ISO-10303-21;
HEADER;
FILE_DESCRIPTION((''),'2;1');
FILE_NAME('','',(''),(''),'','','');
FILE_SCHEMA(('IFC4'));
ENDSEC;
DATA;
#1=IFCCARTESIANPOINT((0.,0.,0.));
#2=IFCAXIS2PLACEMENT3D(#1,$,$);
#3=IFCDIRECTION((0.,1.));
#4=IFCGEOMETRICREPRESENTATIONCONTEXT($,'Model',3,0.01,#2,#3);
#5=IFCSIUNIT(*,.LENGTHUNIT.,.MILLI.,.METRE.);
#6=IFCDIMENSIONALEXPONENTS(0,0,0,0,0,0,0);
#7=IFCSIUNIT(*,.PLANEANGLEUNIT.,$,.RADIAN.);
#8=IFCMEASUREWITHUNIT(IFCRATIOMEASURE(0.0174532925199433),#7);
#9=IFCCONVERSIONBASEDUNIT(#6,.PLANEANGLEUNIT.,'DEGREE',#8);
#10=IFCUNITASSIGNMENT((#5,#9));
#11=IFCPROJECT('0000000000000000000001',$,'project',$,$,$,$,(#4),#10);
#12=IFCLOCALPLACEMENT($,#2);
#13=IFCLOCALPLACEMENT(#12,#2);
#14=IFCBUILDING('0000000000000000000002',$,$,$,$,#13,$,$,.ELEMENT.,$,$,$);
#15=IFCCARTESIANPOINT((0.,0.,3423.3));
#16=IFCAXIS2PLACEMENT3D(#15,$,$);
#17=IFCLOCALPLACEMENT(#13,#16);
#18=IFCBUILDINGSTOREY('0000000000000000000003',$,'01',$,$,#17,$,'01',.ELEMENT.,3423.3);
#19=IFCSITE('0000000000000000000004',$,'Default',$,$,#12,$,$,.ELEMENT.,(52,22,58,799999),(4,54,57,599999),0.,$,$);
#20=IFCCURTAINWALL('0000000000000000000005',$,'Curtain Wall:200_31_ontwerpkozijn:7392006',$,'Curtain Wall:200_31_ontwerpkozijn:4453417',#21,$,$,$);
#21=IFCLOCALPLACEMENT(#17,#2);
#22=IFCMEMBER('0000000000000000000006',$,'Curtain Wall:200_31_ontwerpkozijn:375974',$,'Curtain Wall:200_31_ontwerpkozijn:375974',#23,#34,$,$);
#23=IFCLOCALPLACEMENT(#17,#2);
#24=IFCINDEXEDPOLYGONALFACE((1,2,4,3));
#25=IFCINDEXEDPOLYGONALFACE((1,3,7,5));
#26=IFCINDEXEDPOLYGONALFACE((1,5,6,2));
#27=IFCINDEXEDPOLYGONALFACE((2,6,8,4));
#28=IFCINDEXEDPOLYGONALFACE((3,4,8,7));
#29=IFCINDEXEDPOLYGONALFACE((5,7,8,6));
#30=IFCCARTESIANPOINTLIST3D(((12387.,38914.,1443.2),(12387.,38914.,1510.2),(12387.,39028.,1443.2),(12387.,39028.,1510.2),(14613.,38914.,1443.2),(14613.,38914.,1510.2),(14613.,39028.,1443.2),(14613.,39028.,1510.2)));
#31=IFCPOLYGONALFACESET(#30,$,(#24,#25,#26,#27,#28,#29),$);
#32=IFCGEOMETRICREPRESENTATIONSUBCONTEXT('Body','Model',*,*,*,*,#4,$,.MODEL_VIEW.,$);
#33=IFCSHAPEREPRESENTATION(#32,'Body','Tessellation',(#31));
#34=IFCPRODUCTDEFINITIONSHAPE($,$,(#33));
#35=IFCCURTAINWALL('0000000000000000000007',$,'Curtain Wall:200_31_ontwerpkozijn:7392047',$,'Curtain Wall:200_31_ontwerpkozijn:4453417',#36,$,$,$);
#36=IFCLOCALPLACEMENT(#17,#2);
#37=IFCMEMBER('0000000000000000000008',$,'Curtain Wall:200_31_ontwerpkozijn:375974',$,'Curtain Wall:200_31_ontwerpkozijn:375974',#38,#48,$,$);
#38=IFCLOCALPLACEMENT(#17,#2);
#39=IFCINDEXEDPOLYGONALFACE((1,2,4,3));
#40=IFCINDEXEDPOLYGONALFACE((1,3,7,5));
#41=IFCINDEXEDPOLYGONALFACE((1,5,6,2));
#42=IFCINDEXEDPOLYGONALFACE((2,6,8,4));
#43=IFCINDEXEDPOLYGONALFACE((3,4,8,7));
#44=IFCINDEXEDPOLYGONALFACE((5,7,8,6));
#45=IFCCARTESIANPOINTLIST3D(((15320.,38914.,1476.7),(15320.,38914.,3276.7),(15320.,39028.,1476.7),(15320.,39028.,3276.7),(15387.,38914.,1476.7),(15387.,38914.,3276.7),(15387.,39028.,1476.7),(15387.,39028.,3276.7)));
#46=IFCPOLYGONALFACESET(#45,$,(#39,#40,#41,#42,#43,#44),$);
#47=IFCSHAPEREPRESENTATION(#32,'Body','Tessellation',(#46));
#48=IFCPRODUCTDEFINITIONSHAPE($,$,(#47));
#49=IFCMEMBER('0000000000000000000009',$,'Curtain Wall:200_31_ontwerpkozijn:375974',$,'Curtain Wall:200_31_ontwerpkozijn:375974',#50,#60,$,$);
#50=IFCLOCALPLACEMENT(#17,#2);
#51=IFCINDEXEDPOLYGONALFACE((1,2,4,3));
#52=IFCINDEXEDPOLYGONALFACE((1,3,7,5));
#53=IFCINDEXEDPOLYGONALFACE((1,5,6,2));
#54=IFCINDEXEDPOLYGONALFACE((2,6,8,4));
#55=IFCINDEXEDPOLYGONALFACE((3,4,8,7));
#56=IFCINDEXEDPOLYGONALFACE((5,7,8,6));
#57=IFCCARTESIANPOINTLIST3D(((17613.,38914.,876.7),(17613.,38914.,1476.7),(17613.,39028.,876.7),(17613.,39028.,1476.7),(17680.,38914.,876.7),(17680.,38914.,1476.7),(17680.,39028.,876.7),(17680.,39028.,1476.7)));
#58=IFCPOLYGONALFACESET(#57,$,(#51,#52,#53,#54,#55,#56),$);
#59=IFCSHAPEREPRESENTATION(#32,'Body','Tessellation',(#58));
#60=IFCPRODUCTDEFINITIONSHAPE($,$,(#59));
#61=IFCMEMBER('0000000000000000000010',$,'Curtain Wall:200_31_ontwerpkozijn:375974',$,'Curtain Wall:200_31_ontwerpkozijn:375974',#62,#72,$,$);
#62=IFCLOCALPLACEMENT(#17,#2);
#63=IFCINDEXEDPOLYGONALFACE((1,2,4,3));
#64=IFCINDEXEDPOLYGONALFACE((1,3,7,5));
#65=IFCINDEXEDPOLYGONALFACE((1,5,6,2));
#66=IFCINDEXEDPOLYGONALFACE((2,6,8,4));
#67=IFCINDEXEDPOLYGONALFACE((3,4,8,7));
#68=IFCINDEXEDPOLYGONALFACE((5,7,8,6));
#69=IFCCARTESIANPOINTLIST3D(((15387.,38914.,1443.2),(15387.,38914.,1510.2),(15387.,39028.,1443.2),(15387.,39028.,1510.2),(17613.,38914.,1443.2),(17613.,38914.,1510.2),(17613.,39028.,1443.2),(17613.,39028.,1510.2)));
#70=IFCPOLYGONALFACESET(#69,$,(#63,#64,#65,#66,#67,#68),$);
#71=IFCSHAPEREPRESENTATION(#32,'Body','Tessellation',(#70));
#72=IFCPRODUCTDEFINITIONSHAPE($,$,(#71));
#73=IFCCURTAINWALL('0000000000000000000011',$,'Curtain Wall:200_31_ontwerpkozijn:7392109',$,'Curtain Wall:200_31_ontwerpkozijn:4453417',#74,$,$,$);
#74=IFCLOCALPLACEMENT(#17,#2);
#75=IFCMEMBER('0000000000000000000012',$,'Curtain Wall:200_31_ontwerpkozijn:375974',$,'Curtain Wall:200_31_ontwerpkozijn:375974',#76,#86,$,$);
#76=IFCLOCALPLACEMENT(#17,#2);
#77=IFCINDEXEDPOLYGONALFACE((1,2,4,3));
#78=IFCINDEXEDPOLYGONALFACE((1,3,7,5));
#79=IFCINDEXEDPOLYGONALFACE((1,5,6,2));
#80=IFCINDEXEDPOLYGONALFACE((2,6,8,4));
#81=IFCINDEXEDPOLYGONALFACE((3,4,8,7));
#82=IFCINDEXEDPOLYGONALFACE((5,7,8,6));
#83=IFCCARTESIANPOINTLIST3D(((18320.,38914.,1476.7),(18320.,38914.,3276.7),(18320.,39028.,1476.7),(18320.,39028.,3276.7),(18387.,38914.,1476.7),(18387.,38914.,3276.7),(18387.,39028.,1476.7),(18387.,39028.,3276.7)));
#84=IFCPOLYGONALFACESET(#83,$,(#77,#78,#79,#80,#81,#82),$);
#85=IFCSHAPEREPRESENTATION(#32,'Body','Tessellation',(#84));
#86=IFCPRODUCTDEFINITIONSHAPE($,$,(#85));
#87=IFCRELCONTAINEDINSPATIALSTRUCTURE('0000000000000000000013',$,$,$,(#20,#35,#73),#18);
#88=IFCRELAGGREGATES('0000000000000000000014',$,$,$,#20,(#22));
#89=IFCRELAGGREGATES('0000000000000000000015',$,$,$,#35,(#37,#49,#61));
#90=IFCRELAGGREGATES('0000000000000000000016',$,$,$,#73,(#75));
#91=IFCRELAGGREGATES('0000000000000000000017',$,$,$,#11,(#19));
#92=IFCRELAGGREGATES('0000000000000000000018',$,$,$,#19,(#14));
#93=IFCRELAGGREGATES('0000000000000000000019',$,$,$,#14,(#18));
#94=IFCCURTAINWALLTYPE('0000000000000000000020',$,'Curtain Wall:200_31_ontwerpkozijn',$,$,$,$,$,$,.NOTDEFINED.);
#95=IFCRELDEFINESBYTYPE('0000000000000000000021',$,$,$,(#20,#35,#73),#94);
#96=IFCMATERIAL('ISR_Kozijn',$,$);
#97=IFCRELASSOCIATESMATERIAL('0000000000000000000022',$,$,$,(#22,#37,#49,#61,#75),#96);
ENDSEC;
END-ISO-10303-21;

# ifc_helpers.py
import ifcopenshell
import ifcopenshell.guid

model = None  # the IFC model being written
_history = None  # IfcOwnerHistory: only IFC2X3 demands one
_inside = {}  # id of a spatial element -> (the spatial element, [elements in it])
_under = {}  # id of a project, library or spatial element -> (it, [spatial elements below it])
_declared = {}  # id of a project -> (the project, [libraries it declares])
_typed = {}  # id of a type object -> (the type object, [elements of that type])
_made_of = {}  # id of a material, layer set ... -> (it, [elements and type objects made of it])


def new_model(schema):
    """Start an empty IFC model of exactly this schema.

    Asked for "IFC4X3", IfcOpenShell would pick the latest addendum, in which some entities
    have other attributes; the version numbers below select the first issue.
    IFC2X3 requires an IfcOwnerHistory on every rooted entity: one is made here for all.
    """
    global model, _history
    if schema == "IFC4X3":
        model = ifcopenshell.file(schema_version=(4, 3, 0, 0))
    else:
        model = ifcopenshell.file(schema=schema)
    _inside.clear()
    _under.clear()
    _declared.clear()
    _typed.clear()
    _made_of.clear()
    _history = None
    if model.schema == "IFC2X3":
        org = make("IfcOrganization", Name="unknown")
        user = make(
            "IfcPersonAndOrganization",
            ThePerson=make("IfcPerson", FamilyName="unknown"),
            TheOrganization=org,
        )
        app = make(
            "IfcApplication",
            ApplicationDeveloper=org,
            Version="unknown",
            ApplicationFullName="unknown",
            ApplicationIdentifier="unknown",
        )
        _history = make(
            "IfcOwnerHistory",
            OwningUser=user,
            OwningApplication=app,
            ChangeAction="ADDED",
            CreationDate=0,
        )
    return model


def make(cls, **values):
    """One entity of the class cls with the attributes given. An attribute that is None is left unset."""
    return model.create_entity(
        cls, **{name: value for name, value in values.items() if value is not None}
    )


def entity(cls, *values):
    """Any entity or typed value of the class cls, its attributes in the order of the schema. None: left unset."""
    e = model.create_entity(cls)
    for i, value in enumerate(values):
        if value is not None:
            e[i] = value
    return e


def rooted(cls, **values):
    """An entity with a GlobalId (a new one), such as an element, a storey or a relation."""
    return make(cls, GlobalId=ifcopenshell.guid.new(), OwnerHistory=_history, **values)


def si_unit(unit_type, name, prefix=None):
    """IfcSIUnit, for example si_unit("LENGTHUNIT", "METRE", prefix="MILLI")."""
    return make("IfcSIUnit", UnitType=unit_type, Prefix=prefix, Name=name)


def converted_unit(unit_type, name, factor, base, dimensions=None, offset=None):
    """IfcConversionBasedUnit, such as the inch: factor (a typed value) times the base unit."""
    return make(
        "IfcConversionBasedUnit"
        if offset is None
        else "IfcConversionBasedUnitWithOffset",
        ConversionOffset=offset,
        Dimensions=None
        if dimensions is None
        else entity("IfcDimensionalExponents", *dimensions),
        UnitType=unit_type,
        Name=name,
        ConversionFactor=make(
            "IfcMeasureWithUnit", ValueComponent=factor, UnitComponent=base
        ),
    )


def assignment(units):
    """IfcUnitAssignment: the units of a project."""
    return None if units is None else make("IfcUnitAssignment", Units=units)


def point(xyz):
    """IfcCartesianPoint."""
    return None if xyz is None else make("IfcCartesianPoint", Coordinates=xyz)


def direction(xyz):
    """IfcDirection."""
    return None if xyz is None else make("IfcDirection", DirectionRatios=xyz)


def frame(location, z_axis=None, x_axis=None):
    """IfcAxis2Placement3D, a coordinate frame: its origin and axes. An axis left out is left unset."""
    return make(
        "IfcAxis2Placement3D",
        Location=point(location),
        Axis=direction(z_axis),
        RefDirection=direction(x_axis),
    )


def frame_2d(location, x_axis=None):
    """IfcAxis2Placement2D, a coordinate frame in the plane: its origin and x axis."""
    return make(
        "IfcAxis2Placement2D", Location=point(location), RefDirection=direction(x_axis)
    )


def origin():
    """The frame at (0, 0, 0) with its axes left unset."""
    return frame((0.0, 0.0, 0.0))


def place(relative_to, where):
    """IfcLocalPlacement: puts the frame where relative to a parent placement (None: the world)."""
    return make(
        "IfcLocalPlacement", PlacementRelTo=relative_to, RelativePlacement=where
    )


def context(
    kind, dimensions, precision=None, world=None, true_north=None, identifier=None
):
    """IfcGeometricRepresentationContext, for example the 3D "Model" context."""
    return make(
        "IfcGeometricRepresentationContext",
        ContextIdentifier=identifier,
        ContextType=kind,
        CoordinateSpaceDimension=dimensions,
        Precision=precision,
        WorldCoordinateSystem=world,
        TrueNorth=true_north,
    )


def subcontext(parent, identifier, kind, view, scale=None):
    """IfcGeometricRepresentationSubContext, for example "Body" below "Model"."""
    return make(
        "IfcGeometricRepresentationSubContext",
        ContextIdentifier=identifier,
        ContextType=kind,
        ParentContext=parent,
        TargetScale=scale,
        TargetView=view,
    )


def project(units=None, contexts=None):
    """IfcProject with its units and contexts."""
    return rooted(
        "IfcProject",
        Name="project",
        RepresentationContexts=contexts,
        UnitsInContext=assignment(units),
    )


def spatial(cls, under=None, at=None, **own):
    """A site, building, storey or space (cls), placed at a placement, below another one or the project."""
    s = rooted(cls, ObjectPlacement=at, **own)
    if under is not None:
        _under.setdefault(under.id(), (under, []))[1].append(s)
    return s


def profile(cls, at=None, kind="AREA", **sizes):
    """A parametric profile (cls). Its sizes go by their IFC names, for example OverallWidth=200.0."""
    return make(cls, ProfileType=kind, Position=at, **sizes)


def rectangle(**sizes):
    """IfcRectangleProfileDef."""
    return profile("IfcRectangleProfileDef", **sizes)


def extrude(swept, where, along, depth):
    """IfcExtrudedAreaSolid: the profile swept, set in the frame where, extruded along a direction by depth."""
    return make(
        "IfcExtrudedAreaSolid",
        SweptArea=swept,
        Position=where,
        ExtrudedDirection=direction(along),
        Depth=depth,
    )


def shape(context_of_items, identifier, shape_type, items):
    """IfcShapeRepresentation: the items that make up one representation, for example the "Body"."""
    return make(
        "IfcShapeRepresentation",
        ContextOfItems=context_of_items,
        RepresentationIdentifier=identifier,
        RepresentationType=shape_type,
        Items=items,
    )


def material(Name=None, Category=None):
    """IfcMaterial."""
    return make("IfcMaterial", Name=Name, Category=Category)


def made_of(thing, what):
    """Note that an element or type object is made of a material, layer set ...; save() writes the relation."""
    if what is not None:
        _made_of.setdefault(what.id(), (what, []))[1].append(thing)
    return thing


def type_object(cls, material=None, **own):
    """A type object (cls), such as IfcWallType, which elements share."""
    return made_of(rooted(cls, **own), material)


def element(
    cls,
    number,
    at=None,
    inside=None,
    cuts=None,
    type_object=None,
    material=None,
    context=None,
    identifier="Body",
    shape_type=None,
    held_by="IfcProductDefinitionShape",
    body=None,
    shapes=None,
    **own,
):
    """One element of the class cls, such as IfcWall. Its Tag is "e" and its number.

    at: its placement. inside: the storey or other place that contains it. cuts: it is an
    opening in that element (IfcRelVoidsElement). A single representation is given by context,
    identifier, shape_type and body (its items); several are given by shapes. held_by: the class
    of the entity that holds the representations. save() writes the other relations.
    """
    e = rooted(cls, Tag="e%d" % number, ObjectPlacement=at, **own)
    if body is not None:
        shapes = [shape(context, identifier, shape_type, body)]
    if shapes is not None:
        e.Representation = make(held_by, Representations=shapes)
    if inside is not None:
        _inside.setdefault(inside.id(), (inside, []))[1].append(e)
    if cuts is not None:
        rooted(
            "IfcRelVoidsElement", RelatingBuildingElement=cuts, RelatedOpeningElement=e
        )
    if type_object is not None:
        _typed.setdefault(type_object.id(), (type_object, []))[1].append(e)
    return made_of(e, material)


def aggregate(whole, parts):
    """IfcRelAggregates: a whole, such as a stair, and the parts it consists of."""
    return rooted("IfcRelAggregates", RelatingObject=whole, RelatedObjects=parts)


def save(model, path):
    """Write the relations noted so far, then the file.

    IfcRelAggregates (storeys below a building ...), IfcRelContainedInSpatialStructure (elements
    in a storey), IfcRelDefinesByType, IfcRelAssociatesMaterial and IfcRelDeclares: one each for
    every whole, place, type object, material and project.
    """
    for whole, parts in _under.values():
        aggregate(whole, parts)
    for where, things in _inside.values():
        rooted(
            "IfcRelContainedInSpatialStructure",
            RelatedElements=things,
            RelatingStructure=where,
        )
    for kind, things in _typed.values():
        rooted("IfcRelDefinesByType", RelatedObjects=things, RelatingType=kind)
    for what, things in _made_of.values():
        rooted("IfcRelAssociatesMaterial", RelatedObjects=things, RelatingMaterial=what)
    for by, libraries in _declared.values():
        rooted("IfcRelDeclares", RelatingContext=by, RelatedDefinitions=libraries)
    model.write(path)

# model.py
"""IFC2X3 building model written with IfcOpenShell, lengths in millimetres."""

from ifc_helpers import new_model, entity, si_unit, converted_unit, direction, frame, frame_2d, origin, place, context, subcontext, project, spatial, rectangle, extrude, material, type_object, element, aggregate, save


model = new_model("IFC2X3")

# Units and contexts
model_context = context("Model", 3, precision=0.01, world=origin(), true_north=direction((0.0, 1.0)))
body_context = subcontext(model_context, "Body", "Model", "MODEL_VIEW")
ifc_project = project(units=[si_unit("LENGTHUNIT", "METRE", prefix="MILLI"), converted_unit("PLANEANGLEUNIT", "DEGREE", entity("IfcRatioMeasure", 0.0174532925199433), si_unit("PLANEANGLEUNIT", "RADIAN"), dimensions=[0, 0, 0, 0, 0, 0, 0])], contexts=[model_context])

# Site, building, storey
site_placement = place(None, origin())
site = spatial("IfcSite", under=ifc_project, at=site_placement, Name="Default", CompositionType="ELEMENT", RefLatitude=(52, 22, 58, 799999), RefLongitude=(4, 54, 57, 599999), RefElevation=0.0)
building_placement = place(site_placement, origin())
building = spatial("IfcBuilding", under=site, at=building_placement, CompositionType="ELEMENT")
storey_placement = place(building_placement, frame((0.0, 0.0, 3423.3)))
storey = spatial("IfcBuildingStorey", under=building, at=storey_placement, Name="01", LongName="01", CompositionType="ELEMENT", Elevation=3423.3)

# Curtain walls, members
curtain_wall_type = type_object("IfcCurtainWallType", Name="Curtain Wall:200_31_ontwerpkozijn", PredefinedType="NOTDEFINED")
ifc_material = material(Name="ISR_Kozijn")
curtain_wall_1_placement = place(storey_placement, frame((0.0, 0.0, -3423.3)))
curtain_wall_1 = element("IfcCurtainWall", 1, at=curtain_wall_1_placement, inside=storey, type_object=curtain_wall_type, Name="Curtain Wall:200_31_ontwerpkozijn:7392006", ObjectType="Curtain Wall:200_31_ontwerpkozijn:4453417")
member_1_placement = place(curtain_wall_1_placement, frame((0.0, 0.0, 3423.3)))
member_1 = element("IfcMember", 2, at=member_1_placement, material=ifc_material, Name="Curtain Wall:200_31_ontwerpkozijn:375974", ObjectType="Curtain Wall:200_31_ontwerpkozijn:375974", context=body_context, shape_type="SweptSolid", body=[
    extrude(rectangle(XDim=67.0, YDim=114.0, at=frame_2d((0.0, 0.0), x_axis=(1.0, 0.0))), frame((12387.0, 38971.0, 1476.7), z_axis=(1.0, 0.0, 0.0), x_axis=(0.0, 0.0, -1.0)), (0.0, 0.0, 1.0), 2226.0),
])
aggregate(curtain_wall_1, [member_1])
curtain_wall_2_placement = place(storey_placement, frame((0.0, 0.0, -3423.3)))
curtain_wall_2 = element("IfcCurtainWall", 3, at=curtain_wall_2_placement, inside=storey, type_object=curtain_wall_type, Name="Curtain Wall:200_31_ontwerpkozijn:7392047", ObjectType="Curtain Wall:200_31_ontwerpkozijn:4453417")
member_2_placement = place(curtain_wall_2_placement, frame((0.0, 0.0, 3423.3)))
member_2 = element("IfcMember", 4, at=member_2_placement, material=ifc_material, Name="Curtain Wall:200_31_ontwerpkozijn:375974", ObjectType="Curtain Wall:200_31_ontwerpkozijn:375974", context=body_context, shape_type="SweptSolid", body=[
    extrude(rectangle(XDim=67.0, YDim=114.0, at=frame_2d((0.0, 0.0), x_axis=(1.0, 0.0))), frame((15353.5, 38971.0, 1476.7), z_axis=(0.0, 0.0, 1.0), x_axis=(-1.0, 0.0, 0.0)), (0.0, 0.0, 1.0), 1800.0),
])
member_3_placement = place(curtain_wall_2_placement, frame((0.0, 0.0, 3423.3)))
member_3 = element("IfcMember", 5, at=member_3_placement, material=ifc_material, Name="Curtain Wall:200_31_ontwerpkozijn:375974", ObjectType="Curtain Wall:200_31_ontwerpkozijn:375974", context=body_context, shape_type="SweptSolid", body=[
    extrude(rectangle(XDim=67.0, YDim=114.0, at=frame_2d((0.0, 0.0), x_axis=(1.0, 0.0))), frame((17646.5, 38971.0, 1476.7), z_axis=(0.0, 0.0, -1.0), x_axis=(-1.0, 0.0, 0.0)), (0.0, 0.0, 1.0), 600.0),
])
member_4_placement = place(curtain_wall_2_placement, frame((0.0, 0.0, 3423.3)))
member_4 = element("IfcMember", 6, at=member_4_placement, material=ifc_material, Name="Curtain Wall:200_31_ontwerpkozijn:375974", ObjectType="Curtain Wall:200_31_ontwerpkozijn:375974", context=body_context, shape_type="SweptSolid", body=[
    extrude(rectangle(XDim=67.0, YDim=114.0, at=frame_2d((0.0, 0.0), x_axis=(1.0, 0.0))), frame((15387.0, 38971.0, 1476.7), z_axis=(1.0, 0.0, 0.0), x_axis=(0.0, 0.0, -1.0)), (0.0, 0.0, 1.0), 2226.0),
])
aggregate(curtain_wall_2, [member_2, member_3, member_4])

# Curtain wall, member
curtain_wall_3_placement = place(storey_placement, frame((0.0, 0.0, -3423.3)))
curtain_wall_3 = element("IfcCurtainWall", 7, at=curtain_wall_3_placement, inside=storey, type_object=curtain_wall_type, Name="Curtain Wall:200_31_ontwerpkozijn:7392109", ObjectType="Curtain Wall:200_31_ontwerpkozijn:4453417")
member_5_placement = place(curtain_wall_3_placement, frame((0.0, 0.0, 3423.3)))
member_5 = element("IfcMember", 8, at=member_5_placement, material=ifc_material, Name="Curtain Wall:200_31_ontwerpkozijn:375974", ObjectType="Curtain Wall:200_31_ontwerpkozijn:375974", context=body_context, shape_type="SweptSolid", body=[
    extrude(rectangle(XDim=67.0, YDim=114.0, at=frame_2d((0.0, 0.0), x_axis=(1.0, 0.0))), frame((18353.5, 38971.0, 1476.7), z_axis=(0.0, 0.0, 1.0), x_axis=(-1.0, 0.0, 0.0)), (0.0, 0.0, 1.0), 1800.0),
])
aggregate(curtain_wall_3, [member_5])

save(model, "model.ifc")
